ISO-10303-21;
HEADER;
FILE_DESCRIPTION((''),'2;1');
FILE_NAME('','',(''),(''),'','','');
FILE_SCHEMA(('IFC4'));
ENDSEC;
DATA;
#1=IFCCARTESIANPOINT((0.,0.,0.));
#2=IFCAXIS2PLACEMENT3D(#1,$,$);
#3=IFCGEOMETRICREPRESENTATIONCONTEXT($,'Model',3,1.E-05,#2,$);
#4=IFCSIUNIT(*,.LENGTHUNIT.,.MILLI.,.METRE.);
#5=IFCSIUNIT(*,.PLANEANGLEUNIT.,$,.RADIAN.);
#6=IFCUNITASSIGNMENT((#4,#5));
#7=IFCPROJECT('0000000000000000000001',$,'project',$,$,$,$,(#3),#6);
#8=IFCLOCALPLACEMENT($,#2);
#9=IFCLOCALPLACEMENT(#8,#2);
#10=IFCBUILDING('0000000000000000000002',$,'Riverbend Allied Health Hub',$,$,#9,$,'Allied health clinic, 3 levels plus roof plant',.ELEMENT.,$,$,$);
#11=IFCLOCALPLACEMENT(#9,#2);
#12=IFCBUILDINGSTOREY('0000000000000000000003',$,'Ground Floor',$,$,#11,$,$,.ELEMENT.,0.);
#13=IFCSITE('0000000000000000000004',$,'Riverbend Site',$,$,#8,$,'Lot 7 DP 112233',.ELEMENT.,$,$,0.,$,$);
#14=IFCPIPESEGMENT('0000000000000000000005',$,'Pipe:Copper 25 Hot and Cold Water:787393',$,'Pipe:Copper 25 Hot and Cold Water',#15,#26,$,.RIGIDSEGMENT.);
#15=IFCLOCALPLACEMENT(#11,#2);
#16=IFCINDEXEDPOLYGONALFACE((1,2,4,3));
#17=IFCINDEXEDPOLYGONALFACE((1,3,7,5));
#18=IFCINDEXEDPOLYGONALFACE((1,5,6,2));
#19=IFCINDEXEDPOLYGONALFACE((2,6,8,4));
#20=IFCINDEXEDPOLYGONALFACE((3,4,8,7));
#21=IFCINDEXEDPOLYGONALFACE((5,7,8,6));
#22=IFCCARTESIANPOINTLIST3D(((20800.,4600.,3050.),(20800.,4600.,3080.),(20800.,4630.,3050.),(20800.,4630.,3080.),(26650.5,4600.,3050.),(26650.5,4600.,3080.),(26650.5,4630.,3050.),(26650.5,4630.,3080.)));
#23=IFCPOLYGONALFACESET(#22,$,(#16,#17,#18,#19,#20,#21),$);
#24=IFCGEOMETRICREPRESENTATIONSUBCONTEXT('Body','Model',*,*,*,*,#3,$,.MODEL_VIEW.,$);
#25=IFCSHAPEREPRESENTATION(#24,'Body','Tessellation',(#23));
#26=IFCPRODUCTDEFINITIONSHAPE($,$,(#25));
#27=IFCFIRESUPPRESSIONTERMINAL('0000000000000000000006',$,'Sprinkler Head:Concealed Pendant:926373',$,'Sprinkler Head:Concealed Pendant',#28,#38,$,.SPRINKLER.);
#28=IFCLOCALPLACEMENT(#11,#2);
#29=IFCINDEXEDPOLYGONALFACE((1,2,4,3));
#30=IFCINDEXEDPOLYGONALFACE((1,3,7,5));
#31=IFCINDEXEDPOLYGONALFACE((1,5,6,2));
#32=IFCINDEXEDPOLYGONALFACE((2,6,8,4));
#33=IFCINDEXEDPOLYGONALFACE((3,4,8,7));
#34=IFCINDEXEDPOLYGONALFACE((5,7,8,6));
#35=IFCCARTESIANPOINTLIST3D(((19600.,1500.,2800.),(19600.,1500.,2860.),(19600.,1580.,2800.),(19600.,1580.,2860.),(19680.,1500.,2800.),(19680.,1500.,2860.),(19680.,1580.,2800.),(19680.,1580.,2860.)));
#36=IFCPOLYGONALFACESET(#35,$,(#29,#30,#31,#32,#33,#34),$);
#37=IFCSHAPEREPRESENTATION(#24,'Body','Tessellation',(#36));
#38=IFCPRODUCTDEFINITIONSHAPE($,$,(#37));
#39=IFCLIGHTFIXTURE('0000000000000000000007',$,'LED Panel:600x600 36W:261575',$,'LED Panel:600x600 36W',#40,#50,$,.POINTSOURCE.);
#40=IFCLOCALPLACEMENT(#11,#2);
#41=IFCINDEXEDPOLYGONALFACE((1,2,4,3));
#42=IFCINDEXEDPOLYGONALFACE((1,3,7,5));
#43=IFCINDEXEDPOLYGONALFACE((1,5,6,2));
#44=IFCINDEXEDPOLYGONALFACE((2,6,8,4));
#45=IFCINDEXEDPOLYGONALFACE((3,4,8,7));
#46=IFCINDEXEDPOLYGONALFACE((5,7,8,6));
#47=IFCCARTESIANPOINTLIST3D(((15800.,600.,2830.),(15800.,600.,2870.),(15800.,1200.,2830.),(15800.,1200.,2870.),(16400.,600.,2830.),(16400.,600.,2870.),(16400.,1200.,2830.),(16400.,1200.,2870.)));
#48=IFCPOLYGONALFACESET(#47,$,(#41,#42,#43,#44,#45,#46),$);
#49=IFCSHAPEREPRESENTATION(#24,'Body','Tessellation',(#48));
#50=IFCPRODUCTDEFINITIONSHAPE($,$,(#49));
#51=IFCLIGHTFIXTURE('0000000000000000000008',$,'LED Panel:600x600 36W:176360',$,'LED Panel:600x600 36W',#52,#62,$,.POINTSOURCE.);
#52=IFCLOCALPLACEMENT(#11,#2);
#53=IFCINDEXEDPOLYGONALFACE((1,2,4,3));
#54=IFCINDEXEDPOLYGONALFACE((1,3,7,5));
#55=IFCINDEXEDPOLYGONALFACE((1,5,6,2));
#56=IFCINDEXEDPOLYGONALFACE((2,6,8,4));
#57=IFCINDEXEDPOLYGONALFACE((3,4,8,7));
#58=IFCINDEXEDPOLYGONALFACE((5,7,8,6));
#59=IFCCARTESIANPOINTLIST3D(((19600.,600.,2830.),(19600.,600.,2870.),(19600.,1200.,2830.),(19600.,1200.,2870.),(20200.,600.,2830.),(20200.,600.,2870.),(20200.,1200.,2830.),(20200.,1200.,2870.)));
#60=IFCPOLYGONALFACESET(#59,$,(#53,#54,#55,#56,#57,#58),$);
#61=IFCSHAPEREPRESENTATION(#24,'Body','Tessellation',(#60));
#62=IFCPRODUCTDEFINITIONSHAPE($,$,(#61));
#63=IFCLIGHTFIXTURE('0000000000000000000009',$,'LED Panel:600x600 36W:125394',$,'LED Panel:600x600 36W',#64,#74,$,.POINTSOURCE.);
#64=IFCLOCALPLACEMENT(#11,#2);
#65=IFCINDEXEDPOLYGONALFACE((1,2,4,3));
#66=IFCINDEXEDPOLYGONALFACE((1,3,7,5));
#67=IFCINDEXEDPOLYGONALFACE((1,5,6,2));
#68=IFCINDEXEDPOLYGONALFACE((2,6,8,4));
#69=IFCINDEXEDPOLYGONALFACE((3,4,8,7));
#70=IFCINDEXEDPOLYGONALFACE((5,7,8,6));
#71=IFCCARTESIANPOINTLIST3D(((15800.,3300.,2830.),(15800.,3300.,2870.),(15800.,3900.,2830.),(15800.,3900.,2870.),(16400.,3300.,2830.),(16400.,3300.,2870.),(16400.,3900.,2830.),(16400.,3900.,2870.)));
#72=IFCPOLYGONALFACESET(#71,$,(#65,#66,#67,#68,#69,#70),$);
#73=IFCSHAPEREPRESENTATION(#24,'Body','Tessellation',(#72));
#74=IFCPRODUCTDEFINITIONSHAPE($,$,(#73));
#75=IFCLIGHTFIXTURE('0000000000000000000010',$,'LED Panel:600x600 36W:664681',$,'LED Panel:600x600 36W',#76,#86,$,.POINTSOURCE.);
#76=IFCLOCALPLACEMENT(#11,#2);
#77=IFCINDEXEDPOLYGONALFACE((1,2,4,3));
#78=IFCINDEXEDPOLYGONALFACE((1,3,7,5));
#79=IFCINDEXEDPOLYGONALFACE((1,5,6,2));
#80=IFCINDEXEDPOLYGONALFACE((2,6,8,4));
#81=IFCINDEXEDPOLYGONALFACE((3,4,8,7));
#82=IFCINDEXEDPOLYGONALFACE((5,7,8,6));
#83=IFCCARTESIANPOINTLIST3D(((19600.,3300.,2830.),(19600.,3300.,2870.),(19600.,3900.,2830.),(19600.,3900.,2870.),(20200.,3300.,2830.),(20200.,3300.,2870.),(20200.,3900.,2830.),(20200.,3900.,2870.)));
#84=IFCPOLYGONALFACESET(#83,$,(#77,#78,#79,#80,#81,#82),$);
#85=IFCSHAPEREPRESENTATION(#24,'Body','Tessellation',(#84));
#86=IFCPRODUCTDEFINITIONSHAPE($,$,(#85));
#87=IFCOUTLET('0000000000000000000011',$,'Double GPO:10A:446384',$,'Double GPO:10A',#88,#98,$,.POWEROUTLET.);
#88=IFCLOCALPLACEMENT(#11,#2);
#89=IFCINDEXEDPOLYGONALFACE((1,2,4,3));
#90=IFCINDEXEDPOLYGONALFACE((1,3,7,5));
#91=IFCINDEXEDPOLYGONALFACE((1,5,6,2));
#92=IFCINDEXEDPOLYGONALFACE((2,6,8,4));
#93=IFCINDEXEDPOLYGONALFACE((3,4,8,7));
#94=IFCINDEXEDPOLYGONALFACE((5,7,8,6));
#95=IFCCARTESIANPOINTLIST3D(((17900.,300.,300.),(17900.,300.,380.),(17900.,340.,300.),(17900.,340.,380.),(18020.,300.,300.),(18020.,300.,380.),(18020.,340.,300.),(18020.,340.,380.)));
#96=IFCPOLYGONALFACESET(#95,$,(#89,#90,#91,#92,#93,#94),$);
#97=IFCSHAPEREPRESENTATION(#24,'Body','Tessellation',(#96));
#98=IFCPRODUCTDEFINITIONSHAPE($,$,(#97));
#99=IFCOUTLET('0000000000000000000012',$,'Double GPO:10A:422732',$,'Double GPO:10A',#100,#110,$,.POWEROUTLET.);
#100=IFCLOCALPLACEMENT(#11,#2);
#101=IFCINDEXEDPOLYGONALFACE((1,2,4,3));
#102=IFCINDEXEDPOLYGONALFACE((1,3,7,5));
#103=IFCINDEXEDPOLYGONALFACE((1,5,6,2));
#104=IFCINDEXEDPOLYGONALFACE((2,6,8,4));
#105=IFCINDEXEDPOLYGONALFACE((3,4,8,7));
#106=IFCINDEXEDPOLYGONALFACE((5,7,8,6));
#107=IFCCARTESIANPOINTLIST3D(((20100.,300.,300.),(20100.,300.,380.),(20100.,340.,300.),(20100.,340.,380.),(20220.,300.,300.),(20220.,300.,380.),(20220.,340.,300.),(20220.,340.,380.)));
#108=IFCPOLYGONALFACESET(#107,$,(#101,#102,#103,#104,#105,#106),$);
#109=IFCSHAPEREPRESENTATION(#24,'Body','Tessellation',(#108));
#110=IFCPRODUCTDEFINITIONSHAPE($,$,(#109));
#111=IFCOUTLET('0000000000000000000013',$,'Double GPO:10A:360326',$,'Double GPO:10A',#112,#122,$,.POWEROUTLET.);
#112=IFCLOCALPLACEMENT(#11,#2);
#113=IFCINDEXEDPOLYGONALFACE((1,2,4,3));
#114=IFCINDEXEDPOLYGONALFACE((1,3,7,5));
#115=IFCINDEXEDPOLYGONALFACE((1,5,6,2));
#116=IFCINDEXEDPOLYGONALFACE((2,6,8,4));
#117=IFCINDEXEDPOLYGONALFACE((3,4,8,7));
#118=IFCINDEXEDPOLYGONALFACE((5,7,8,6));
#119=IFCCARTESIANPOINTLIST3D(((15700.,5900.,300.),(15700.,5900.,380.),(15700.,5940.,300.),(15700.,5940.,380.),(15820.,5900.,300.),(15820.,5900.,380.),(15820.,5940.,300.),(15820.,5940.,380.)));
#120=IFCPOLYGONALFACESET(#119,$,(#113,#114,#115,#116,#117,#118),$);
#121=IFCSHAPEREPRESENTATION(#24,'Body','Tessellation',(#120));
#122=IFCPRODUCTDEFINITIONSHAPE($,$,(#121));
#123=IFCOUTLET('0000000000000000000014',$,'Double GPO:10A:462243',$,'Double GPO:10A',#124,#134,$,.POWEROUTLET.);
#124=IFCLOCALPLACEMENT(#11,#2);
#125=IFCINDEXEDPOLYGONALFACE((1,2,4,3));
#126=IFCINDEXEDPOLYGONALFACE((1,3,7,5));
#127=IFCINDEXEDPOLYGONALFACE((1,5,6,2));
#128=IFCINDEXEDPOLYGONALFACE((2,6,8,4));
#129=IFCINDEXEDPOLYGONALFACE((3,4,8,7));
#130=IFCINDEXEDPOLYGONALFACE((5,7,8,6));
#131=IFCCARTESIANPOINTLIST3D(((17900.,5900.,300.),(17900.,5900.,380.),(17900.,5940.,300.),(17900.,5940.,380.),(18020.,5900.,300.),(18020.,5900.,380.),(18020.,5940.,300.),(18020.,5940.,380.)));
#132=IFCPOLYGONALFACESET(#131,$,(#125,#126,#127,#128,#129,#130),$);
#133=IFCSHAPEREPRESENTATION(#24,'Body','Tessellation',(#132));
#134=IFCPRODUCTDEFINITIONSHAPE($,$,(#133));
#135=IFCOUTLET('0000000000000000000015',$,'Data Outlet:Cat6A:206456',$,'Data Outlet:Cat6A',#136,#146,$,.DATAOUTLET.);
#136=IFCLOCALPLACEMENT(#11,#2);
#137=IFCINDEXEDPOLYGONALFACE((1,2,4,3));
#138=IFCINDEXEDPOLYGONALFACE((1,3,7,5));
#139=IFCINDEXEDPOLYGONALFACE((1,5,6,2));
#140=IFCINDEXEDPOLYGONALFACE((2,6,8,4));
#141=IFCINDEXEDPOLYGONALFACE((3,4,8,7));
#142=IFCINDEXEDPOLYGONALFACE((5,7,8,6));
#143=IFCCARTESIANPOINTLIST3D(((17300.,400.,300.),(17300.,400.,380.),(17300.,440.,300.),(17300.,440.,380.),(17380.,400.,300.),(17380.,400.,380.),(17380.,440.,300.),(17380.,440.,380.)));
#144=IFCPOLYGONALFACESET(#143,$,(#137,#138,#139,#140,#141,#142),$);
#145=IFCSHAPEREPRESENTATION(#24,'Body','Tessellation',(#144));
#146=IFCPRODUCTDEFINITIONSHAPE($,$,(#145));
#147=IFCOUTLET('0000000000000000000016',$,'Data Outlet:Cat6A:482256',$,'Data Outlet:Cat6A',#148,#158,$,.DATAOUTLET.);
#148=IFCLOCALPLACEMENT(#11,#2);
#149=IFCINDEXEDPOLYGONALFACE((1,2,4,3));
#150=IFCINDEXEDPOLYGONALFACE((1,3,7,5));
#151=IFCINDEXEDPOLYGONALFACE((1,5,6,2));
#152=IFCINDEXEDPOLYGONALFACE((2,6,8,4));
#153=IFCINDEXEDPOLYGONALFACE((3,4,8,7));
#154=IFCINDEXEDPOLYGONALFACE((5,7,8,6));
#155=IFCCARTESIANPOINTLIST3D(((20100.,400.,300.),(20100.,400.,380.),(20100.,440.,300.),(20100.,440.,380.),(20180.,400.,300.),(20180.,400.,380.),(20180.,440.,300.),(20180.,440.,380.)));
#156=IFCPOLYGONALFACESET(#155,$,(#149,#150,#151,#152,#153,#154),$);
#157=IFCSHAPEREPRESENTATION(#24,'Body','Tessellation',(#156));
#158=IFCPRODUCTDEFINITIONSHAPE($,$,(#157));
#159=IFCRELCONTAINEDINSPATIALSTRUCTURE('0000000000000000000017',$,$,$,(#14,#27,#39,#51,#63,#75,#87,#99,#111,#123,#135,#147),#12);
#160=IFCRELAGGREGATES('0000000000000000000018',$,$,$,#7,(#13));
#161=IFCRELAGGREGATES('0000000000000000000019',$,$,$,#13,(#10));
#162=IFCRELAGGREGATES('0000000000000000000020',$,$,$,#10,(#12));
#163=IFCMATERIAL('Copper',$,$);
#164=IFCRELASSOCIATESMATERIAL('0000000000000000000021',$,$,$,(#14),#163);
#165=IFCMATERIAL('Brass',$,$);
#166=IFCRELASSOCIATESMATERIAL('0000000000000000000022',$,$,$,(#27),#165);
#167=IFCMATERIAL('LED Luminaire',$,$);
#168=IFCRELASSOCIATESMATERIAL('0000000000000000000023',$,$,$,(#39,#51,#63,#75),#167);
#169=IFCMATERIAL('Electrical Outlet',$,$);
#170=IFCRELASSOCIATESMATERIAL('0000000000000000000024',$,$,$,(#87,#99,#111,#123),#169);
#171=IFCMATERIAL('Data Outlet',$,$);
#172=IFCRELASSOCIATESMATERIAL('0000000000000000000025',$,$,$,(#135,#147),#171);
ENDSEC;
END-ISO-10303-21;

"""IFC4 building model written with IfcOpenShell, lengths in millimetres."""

from ifc_helpers import new_model, si_unit, frame, frame_2d, origin, place, context, subcontext, project, spatial, rectangle, extrude, material, element, save


model = new_model("IFC4")

# Units and contexts
model_context = context("Model", 3, precision=1e-05, world=origin())
body_context = subcontext(model_context, "Body", "Model", "MODEL_VIEW")
ifc_project = project(units=[si_unit("LENGTHUNIT", "METRE", prefix="MILLI"), si_unit("PLANEANGLEUNIT", "RADIAN")], contexts=[model_context])

# Site, building, storey
site_placement = place(None, origin())
site = spatial("IfcSite", under=ifc_project, at=site_placement, Name="Riverbend Site", LongName="Lot 7 DP 112233", CompositionType="ELEMENT", RefElevation=0.0)
building_placement = place(site_placement, origin())
building = spatial("IfcBuilding", under=site, at=building_placement, Name="Riverbend Allied Health Hub", LongName="Allied health clinic, 3 levels plus roof plant", CompositionType="ELEMENT")
storey_placement = place(building_placement, origin())
storey = spatial("IfcBuildingStorey", under=building, at=storey_placement, Name="Ground Floor", CompositionType="ELEMENT", Elevation=0.0)

# Pipe segment
ifc_material_1 = material(Name="Copper")
pipe_segment_1_placement = place(storey_placement, frame((20800.0, 4600.0, 3050.0)))
element("IfcPipeSegment", 1, at=pipe_segment_1_placement, inside=storey, material=ifc_material_1, Name="Pipe:Copper 25 Hot and Cold Water:787393", ObjectType="Pipe:Copper 25 Hot and Cold Water", PredefinedType="RIGIDSEGMENT", context=body_context, shape_type="SweptSolid", body=[
    extrude(rectangle(XDim=5850.5, YDim=30.0, at=frame_2d((2925.3, 15.0))), origin(), (0.0, 0.0, 1.0), 30.0),
])

# Fire suppression terminal
ifc_material_2 = material(Name="Brass")
fire_suppression_terminal_placement = place(storey_placement, frame((19600.0, 1500.0, 2800.0)))
element("IfcFireSuppressionTerminal", 2, at=fire_suppression_terminal_placement, inside=storey, material=ifc_material_2, Name="Sprinkler Head:Concealed Pendant:926373", ObjectType="Sprinkler Head:Concealed Pendant", PredefinedType="SPRINKLER", context=body_context, shape_type="SweptSolid", body=[
    extrude(rectangle(XDim=80.0, YDim=80.0, at=frame_2d((40.0, 40.0))), origin(), (0.0, 0.0, 1.0), 60.0),
])

# Light fixtures
ifc_material_3 = material(Name="LED Luminaire")
for number, where, name in (
    (3, (15800.0, 600.0, 2830.0), "LED Panel:600x600 36W:261575"),
    (4, (19600.0, 600.0, 2830.0), "LED Panel:600x600 36W:176360"),
    (5, (15800.0, 3300.0, 2830.0), "LED Panel:600x600 36W:125394"),
    (6, (19600.0, 3300.0, 2830.0), "LED Panel:600x600 36W:664681"),
):
    element("IfcLightFixture", number, at=place(storey_placement, frame(where)), inside=storey, material=ifc_material_3, Name=name, ObjectType="LED Panel:600x600 36W", PredefinedType="POINTSOURCE", context=body_context, shape_type="SweptSolid", body=[
        extrude(rectangle(XDim=600.0, YDim=600.0, at=frame_2d((300.0, 300.0))), origin(), (0.0, 0.0, 1.0), 40.0),
    ])

# Outlets
ifc_material_4 = material(Name="Electrical Outlet")
for number, where, name in (
    (7, (17900.0, 300.0, 300.0), "Double GPO:10A:446384"),
    (8, (20100.0, 300.0, 300.0), "Double GPO:10A:422732"),
    (9, (15700.0, 5900.0, 300.0), "Double GPO:10A:360326"),
    (10, (17900.0, 5900.0, 300.0), "Double GPO:10A:462243"),
):
    element("IfcOutlet", number, at=place(storey_placement, frame(where)), inside=storey, material=ifc_material_4, Name=name, ObjectType="Double GPO:10A", PredefinedType="POWEROUTLET", context=body_context, shape_type="SweptSolid", body=[
        extrude(rectangle(XDim=120.0, YDim=40.0, at=frame_2d((60.0, 20.0))), origin(), (0.0, 0.0, 1.0), 80.0),
    ])
ifc_material_5 = material(Name="Data Outlet")
for number, where, name in (
    (11, (17300.0, 400.0, 300.0), "Data Outlet:Cat6A:206456"),
    (12, (20100.0, 400.0, 300.0), "Data Outlet:Cat6A:482256"),
):
    element("IfcOutlet", number, at=place(storey_placement, frame(where)), inside=storey, material=ifc_material_5, Name=name, ObjectType="Data Outlet:Cat6A", PredefinedType="DATAOUTLET", context=body_context, shape_type="SweptSolid", body=[
        extrude(rectangle(XDim=80.0, YDim=40.0, at=frame_2d((40.0, 20.0))), origin(), (0.0, 0.0, 1.0), 80.0),
    ])

save(model, "model.ifc")
